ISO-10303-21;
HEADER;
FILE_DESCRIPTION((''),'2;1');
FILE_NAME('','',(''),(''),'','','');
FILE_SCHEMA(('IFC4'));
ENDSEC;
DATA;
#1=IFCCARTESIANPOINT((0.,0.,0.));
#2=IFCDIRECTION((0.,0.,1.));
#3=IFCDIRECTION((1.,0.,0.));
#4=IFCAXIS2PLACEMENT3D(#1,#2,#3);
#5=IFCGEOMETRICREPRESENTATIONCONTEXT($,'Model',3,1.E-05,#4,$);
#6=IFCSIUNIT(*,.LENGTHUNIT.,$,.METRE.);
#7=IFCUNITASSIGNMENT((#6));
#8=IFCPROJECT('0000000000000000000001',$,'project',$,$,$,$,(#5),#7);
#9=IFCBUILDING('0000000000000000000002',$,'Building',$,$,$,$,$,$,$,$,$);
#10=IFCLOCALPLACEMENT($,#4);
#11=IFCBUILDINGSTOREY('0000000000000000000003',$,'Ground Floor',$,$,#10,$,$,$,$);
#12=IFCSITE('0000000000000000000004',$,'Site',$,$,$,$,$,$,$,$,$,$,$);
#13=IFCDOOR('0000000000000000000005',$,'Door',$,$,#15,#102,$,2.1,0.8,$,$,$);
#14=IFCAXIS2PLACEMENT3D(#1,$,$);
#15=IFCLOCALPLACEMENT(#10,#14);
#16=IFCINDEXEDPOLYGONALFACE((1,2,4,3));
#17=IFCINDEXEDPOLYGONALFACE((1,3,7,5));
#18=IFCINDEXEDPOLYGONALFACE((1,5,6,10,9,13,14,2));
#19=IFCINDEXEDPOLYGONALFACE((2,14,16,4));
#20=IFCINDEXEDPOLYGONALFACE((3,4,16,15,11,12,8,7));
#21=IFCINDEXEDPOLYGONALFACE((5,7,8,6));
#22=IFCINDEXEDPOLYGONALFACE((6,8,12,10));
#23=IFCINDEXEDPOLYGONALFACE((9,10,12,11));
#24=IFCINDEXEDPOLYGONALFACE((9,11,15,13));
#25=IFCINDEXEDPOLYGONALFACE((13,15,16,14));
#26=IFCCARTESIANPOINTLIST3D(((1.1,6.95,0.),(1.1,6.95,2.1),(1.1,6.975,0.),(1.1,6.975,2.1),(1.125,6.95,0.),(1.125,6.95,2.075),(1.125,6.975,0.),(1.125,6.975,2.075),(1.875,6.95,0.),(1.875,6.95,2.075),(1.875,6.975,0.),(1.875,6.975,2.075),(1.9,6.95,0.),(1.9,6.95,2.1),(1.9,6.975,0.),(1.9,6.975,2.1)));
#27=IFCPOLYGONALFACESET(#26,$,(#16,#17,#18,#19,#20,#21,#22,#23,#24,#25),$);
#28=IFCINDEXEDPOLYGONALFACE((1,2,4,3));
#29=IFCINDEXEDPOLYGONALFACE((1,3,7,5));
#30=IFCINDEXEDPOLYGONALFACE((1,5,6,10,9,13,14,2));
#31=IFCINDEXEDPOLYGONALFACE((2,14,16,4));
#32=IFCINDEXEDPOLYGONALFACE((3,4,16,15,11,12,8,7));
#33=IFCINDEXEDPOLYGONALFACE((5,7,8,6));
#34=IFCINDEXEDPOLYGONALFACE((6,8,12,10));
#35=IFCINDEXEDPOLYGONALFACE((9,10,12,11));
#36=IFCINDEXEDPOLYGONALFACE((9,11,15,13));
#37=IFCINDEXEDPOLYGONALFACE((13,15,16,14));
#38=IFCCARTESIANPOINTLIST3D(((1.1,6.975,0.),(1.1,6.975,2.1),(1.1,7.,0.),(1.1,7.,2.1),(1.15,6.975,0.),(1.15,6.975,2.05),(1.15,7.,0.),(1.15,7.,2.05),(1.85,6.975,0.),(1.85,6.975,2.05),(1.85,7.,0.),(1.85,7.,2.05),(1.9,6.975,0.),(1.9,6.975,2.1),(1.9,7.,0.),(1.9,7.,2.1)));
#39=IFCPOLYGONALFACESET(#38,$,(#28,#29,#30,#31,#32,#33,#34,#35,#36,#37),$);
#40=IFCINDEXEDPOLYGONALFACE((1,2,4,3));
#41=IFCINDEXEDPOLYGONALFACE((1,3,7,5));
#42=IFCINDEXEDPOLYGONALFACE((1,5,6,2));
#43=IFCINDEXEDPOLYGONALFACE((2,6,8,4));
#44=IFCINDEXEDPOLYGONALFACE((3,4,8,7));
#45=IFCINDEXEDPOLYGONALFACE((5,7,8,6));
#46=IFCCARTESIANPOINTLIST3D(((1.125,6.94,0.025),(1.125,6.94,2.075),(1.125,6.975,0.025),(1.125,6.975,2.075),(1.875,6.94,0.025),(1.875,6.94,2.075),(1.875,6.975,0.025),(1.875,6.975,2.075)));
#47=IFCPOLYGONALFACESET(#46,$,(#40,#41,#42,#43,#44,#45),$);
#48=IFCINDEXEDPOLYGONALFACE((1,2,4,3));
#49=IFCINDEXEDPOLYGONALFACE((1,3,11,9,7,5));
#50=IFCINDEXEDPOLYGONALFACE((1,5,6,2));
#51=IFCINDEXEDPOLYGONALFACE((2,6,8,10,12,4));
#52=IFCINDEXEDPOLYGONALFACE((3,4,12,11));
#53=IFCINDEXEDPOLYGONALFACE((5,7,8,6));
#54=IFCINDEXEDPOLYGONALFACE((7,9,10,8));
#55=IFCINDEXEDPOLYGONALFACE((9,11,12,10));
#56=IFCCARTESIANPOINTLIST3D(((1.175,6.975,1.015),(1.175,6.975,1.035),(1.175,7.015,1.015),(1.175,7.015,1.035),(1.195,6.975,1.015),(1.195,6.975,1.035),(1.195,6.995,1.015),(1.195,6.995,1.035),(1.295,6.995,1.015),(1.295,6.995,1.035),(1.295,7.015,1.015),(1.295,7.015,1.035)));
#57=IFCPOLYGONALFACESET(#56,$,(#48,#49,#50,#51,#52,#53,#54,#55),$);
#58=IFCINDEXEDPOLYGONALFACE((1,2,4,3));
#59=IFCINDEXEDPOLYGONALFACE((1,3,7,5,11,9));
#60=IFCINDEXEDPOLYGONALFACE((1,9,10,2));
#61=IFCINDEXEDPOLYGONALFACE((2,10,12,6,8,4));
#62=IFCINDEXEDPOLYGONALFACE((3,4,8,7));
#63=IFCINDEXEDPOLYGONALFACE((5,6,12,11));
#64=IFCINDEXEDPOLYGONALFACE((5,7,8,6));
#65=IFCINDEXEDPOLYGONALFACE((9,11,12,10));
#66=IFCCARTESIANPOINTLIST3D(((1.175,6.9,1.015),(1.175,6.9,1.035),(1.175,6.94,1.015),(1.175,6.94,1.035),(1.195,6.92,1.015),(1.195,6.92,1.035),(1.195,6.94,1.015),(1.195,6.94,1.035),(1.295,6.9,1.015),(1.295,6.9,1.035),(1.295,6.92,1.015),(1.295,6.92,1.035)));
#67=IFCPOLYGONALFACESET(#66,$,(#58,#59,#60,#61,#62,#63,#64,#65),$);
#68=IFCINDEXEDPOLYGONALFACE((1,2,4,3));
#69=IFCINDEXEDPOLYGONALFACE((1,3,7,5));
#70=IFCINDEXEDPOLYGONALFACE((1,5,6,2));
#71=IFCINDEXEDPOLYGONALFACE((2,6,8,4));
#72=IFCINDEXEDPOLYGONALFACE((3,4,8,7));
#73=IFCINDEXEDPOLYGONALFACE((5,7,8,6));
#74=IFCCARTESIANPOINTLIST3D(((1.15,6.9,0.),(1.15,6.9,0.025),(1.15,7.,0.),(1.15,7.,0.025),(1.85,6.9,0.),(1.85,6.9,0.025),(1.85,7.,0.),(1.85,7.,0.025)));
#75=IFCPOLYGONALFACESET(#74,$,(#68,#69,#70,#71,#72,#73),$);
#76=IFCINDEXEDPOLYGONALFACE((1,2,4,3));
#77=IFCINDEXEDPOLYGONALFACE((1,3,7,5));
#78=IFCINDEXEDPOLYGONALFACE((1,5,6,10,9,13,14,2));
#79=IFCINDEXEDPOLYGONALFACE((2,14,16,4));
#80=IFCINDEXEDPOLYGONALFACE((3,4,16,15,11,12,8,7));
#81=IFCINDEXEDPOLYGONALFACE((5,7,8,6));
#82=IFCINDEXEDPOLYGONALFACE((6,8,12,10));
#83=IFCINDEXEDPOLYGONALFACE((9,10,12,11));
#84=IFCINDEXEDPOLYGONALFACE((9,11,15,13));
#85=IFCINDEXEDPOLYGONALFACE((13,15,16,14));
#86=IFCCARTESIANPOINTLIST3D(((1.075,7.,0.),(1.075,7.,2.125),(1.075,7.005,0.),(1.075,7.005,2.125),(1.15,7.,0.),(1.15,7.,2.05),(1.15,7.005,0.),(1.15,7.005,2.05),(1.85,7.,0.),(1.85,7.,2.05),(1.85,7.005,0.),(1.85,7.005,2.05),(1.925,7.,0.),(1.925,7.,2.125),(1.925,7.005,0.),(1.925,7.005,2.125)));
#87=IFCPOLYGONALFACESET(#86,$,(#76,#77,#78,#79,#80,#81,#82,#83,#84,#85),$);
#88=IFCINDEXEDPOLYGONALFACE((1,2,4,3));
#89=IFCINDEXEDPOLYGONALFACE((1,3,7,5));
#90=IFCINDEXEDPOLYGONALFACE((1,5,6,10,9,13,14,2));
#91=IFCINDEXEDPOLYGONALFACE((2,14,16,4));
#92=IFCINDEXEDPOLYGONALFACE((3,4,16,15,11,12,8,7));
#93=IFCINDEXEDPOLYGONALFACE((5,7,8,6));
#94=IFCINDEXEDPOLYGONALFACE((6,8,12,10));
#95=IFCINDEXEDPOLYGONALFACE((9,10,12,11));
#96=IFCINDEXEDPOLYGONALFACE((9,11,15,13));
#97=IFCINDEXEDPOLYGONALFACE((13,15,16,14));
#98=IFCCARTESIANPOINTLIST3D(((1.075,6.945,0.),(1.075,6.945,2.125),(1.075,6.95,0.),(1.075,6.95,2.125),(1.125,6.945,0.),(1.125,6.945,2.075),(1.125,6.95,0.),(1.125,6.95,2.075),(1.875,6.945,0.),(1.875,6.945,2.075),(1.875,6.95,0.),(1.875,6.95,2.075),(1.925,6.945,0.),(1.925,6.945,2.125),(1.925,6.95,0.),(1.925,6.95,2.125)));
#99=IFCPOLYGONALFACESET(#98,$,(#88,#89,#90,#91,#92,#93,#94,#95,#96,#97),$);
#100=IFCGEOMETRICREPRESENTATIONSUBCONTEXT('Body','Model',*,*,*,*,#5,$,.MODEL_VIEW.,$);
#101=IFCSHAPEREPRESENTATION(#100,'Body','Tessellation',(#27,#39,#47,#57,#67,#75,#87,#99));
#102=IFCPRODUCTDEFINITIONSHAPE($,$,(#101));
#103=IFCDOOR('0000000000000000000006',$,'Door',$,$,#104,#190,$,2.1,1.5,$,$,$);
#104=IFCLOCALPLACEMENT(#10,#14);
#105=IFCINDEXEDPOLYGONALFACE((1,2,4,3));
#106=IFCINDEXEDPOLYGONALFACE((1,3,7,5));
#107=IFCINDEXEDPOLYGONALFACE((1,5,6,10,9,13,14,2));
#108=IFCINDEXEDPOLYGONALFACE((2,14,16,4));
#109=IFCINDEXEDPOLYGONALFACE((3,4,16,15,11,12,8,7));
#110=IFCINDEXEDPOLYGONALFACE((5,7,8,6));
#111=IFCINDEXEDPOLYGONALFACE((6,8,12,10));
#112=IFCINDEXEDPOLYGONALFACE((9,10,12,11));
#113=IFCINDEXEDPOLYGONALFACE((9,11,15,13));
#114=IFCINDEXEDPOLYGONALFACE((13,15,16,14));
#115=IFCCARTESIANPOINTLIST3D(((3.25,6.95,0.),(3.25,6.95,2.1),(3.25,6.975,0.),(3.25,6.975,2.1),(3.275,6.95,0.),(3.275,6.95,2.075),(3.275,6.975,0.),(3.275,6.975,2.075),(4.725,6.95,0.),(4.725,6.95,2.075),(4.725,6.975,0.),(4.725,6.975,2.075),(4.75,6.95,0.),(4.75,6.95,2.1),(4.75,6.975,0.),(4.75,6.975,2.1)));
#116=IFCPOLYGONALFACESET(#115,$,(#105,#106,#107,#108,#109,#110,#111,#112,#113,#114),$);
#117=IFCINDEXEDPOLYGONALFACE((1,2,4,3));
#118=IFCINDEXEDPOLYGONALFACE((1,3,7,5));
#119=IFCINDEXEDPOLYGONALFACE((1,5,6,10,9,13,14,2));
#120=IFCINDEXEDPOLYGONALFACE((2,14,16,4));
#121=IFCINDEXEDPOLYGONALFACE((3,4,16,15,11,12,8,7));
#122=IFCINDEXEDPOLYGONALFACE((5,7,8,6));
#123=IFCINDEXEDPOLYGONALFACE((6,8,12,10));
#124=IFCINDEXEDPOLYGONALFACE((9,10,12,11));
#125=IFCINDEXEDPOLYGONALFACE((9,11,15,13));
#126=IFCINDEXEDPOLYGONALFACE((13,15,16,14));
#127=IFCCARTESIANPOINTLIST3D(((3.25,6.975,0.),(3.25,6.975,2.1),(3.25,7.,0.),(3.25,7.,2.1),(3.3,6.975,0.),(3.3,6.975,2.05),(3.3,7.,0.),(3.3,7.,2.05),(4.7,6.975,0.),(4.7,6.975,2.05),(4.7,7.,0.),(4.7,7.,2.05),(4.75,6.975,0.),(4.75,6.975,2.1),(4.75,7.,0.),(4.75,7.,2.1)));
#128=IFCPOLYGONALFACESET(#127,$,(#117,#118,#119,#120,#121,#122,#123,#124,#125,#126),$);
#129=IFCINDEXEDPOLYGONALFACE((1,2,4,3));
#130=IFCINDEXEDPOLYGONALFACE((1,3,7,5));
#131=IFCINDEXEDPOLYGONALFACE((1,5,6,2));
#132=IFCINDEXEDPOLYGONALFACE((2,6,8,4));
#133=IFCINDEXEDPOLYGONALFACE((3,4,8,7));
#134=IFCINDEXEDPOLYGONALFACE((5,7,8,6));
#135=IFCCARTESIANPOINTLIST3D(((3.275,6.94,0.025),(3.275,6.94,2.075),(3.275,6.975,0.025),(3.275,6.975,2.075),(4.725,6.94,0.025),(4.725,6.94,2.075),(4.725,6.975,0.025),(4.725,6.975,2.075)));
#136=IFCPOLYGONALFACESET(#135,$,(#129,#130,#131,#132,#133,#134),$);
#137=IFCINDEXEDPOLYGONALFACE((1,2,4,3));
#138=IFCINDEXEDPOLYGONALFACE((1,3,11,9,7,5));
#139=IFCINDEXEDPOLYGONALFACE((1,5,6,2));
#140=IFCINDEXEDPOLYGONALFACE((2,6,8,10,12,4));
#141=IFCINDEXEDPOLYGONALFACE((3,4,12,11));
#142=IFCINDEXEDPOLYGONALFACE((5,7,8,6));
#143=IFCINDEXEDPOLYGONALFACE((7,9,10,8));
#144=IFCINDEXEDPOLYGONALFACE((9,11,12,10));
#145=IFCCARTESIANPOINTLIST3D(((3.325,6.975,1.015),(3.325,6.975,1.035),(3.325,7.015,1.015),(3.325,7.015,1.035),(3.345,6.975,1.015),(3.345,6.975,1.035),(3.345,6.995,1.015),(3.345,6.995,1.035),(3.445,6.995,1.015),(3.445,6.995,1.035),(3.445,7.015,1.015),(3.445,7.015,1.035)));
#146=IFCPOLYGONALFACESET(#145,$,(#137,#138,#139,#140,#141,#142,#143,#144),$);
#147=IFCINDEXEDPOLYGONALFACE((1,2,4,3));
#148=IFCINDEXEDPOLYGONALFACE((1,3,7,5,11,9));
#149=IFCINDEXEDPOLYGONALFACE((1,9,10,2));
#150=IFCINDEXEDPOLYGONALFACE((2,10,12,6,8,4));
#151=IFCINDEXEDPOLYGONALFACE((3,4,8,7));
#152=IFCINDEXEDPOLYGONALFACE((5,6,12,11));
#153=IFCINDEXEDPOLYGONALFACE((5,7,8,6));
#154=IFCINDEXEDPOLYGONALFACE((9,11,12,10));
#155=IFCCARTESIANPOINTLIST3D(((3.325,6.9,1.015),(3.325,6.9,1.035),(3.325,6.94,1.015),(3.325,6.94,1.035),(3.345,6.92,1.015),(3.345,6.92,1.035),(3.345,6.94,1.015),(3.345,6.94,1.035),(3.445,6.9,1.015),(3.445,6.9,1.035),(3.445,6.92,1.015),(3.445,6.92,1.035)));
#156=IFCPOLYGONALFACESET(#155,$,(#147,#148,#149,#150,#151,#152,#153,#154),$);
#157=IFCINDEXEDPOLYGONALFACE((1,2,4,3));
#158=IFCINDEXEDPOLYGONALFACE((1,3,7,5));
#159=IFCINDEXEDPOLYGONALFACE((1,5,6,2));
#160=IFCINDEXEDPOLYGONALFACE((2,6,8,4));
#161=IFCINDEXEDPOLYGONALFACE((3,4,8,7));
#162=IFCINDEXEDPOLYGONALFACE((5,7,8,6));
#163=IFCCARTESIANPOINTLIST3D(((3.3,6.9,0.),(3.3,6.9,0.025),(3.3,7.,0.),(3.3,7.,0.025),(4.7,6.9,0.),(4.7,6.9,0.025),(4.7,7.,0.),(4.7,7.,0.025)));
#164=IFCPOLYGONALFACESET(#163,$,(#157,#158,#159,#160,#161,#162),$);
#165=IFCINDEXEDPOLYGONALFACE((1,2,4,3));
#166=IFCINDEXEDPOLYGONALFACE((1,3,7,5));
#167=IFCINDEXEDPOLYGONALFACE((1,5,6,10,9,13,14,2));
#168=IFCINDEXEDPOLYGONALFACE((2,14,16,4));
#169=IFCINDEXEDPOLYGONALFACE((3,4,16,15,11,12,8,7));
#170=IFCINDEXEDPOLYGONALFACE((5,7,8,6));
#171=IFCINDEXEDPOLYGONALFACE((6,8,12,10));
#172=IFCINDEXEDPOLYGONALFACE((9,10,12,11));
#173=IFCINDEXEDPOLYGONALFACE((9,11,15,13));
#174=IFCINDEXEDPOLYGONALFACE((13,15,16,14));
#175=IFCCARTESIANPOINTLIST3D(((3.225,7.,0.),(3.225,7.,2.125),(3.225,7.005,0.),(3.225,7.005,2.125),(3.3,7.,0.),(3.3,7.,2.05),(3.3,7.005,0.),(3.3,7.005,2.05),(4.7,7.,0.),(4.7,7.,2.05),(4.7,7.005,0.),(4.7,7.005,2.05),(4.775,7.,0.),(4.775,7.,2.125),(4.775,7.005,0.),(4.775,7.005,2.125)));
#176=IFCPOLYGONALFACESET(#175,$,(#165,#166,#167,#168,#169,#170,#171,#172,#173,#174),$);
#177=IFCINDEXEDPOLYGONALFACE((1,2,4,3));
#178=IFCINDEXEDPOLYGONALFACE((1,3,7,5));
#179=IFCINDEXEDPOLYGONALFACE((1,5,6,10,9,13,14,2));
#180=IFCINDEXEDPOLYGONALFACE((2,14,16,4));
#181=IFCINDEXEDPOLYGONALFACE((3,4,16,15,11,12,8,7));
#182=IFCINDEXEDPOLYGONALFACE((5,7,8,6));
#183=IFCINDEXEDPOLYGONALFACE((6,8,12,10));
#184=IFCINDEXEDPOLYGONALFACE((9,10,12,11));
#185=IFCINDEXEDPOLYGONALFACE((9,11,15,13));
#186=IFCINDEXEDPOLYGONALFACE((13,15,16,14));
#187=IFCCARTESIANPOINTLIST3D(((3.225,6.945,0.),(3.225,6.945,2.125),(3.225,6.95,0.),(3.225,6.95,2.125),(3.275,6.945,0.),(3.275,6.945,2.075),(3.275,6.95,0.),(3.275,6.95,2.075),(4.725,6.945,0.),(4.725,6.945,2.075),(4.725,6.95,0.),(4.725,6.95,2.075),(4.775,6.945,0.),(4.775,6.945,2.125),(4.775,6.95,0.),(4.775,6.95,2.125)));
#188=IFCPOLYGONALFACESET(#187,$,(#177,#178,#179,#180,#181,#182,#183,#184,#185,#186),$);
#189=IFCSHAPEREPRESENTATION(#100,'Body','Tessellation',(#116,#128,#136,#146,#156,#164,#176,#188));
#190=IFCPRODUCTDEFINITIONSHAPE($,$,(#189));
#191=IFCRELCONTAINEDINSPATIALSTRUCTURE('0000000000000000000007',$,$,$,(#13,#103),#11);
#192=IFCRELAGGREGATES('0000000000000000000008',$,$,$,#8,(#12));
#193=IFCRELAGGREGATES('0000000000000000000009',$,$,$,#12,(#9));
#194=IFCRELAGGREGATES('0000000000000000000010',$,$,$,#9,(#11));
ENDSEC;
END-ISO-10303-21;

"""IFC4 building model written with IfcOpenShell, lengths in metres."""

from ifc_helpers import new_model, si_unit, frame, origin_with_axes, place, context, subcontext, project, spatial, line, indexed_curve, outline, extrude, element, save


model = new_model("IFC4")

# Units and contexts
model_context = context("Model", 3, precision=1e-05, world=origin_with_axes())
body_context = subcontext(model_context, "Body", "Model", "MODEL_VIEW")
ifc_project = project(units=[si_unit("LENGTHUNIT", "METRE")], contexts=[model_context])

# Site, building, storey
site = spatial("IfcSite", under=ifc_project, Name="Site")
building = spatial("IfcBuilding", under=site, Name="Building")
storey_placement = place(None, origin_with_axes())
storey = spatial("IfcBuildingStorey", under=building, at=storey_placement, Name="Ground Floor")

# Doors
door_1_placement = place(storey_placement, frame((1.9, 7.0, 0.0), z_axis=(0.0, 0.0, 1.0), x_axis=(-1.0, 0.0, 0.0)))
element("IfcDoor", 1, at=door_1_placement, inside=storey, Name="Door", OverallHeight=2.1, OverallWidth=0.8, context=body_context, shape_type="SweptSolid", body=[
    extrude(outline(indexed_curve([(0.0, 0.0), (0.0, 2.1), (0.8, 2.1), (0.8, 0.0), (0.775, 0.0), (0.775, 2.075), (0.025, 2.075), (0.025, 0.0)], segments=[line(1, 2, 3, 4, 5, 6, 7, 8, 1)])), frame((0.0, 0.025, 0.0), z_axis=(0.0, -1.0, 0.0), x_axis=(1.0, 0.0, 0.0)), (0.0, 0.0, -1.0), 0.025),
    extrude(outline(indexed_curve([(0.0, 0.0), (0.0, 2.1), (0.8, 2.1), (0.8, 0.0), (0.75, 0.0), (0.75, 2.05), (0.05, 2.05), (0.05, 0.0)], segments=[line(1, 2, 3, 4, 5, 6, 7, 8, 1)])), frame((0.0, 0.0, 0.0), z_axis=(0.0, -1.0, 0.0), x_axis=(1.0, 0.0, 0.0)), (0.0, 0.0, -1.0), 0.025),
    extrude(outline(indexed_curve([(0.0, 0.0), (0.75, 0.0), (0.75, 0.035), (0.0, 0.035)], segments=[line(1, 2, 3, 4, 1)])), frame((0.025, 0.025, 0.025), z_axis=(0.0, 0.0, 1.0), x_axis=(1.0, 0.0, 0.0)), (0.0, 0.0, 1.0), 2.05),
    extrude(outline(indexed_curve([(0.0, 0.0), (0.0, -0.04), (-0.12, -0.04), (-0.12, -0.02), (-0.02, -0.02), (-0.02, 0.0)], segments=[line(1, 2, 3, 4, 5, 6, 1)])), frame((0.725, 0.025, 1.015), z_axis=(0.0, 0.0, 1.0), x_axis=(1.0, 0.0, 0.0)), (0.0, 0.0, 1.0), 0.02),
    extrude(outline(indexed_curve([(0.0, 0.0), (0.0, 0.04), (-0.12, 0.04), (-0.12, 0.02), (-0.02, 0.02), (-0.02, 0.0)], segments=[line(1, 2, 3, 4, 5, 6, 1)])), frame((0.725, 0.06, 1.015), z_axis=(0.0, 0.0, 1.0), x_axis=(1.0, 0.0, 0.0)), (0.0, 0.0, 1.0), 0.02),
    extrude(outline(indexed_curve([(0.0, 0.0), (0.7, 0.0), (0.7, 0.1), (0.0, 0.1)], segments=[line(1, 2, 3, 4, 1)])), frame((0.05, 0.0, 0.0), z_axis=(0.0, 0.0, 1.0), x_axis=(1.0, 0.0, 0.0)), (0.0, 0.0, 1.0), 0.025),
    extrude(outline(indexed_curve([(0.0, 0.0), (0.0, 2.125), (0.85, 2.125), (0.85, 0.0), (0.775, 0.0), (0.775, 2.05), (0.075, 2.05), (0.075, 0.0)], segments=[line(1, 2, 3, 4, 5, 6, 7, 8, 1)])), frame((-0.025, -0.005, 0.0), z_axis=(0.0, -1.0, 0.0), x_axis=(1.0, 0.0, 0.0)), (0.0, 0.0, -1.0), 0.005),
    extrude(outline(indexed_curve([(0.0, 0.0), (0.0, 2.125), (0.85, 2.125), (0.85, 0.0), (0.8, 0.0), (0.8, 2.075), (0.05, 2.075), (0.05, 0.0)], segments=[line(1, 2, 3, 4, 5, 6, 7, 8, 1)])), frame((-0.025, 0.05, 0.0), z_axis=(0.0, -1.0, 0.0), x_axis=(1.0, 0.0, 0.0)), (0.0, 0.0, -1.0), 0.005),
])
door_2_placement = place(storey_placement, frame((4.75, 7.0, 0.0), z_axis=(0.0, 0.0, 1.0), x_axis=(-1.0, 0.0, 0.0)))
element("IfcDoor", 2, at=door_2_placement, inside=storey, Name="Door", OverallHeight=2.1, OverallWidth=1.5, context=body_context, shape_type="SweptSolid", body=[
    extrude(outline(indexed_curve([(0.0, 0.0), (0.0, 2.1), (1.5, 2.1), (1.5, 0.0), (1.475, 0.0), (1.475, 2.075), (0.025, 2.075), (0.025, 0.0)], segments=[line(1, 2, 3, 4, 5, 6, 7, 8, 1)])), frame((0.0, 0.025, 0.0), z_axis=(0.0, -1.0, 0.0), x_axis=(1.0, 0.0, 0.0)), (0.0, 0.0, -1.0), 0.025),
    extrude(outline(indexed_curve([(0.0, 0.0), (0.0, 2.1), (1.5, 2.1), (1.5, 0.0), (1.45, 0.0), (1.45, 2.05), (0.05, 2.05), (0.05, 0.0)], segments=[line(1, 2, 3, 4, 5, 6, 7, 8, 1)])), frame((0.0, 0.0, 0.0), z_axis=(0.0, -1.0, 0.0), x_axis=(1.0, 0.0, 0.0)), (0.0, 0.0, -1.0), 0.025),
    extrude(outline(indexed_curve([(0.0, 0.0), (1.45, 0.0), (1.45, 0.035), (0.0, 0.035)], segments=[line(1, 2, 3, 4, 1)])), frame((0.025, 0.025, 0.025), z_axis=(0.0, 0.0, 1.0), x_axis=(1.0, 0.0, 0.0)), (0.0, 0.0, 1.0), 2.05),
    extrude(outline(indexed_curve([(0.0, 0.0), (0.0, -0.04), (-0.12, -0.04), (-0.12, -0.02), (-0.02, -0.02), (-0.02, 0.0)], segments=[line(1, 2, 3, 4, 5, 6, 1)])), frame((1.425, 0.025, 1.015), z_axis=(0.0, 0.0, 1.0), x_axis=(1.0, 0.0, 0.0)), (0.0, 0.0, 1.0), 0.02),
    extrude(outline(indexed_curve([(0.0, 0.0), (0.0, 0.04), (-0.12, 0.04), (-0.12, 0.02), (-0.02, 0.02), (-0.02, 0.0)], segments=[line(1, 2, 3, 4, 5, 6, 1)])), frame((1.425, 0.06, 1.015), z_axis=(0.0, 0.0, 1.0), x_axis=(1.0, 0.0, 0.0)), (0.0, 0.0, 1.0), 0.02),
    extrude(outline(indexed_curve([(0.0, 0.0), (1.4, 0.0), (1.4, 0.1), (0.0, 0.1)], segments=[line(1, 2, 3, 4, 1)])), frame((0.05, 0.0, 0.0), z_axis=(0.0, 0.0, 1.0), x_axis=(1.0, 0.0, 0.0)), (0.0, 0.0, 1.0), 0.025),
    extrude(outline(indexed_curve([(0.0, 0.0), (0.0, 2.125), (1.55, 2.125), (1.55, 0.0), (1.475, 0.0), (1.475, 2.05), (0.075, 2.05), (0.075, 0.0)], segments=[line(1, 2, 3, 4, 5, 6, 7, 8, 1)])), frame((-0.025, -0.005, 0.0), z_axis=(0.0, -1.0, 0.0), x_axis=(1.0, 0.0, 0.0)), (0.0, 0.0, -1.0), 0.005),
    extrude(outline(indexed_curve([(0.0, 0.0), (0.0, 2.125), (1.55, 2.125), (1.55, 0.0), (1.5, 0.0), (1.5, 2.075), (0.05, 2.075), (0.05, 0.0)], segments=[line(1, 2, 3, 4, 5, 6, 7, 8, 1)])), frame((-0.025, 0.05, 0.0), z_axis=(0.0, -1.0, 0.0), x_axis=(1.0, 0.0, 0.0)), (0.0, 0.0, -1.0), 0.005),
])

save(model, "model.ifc")
